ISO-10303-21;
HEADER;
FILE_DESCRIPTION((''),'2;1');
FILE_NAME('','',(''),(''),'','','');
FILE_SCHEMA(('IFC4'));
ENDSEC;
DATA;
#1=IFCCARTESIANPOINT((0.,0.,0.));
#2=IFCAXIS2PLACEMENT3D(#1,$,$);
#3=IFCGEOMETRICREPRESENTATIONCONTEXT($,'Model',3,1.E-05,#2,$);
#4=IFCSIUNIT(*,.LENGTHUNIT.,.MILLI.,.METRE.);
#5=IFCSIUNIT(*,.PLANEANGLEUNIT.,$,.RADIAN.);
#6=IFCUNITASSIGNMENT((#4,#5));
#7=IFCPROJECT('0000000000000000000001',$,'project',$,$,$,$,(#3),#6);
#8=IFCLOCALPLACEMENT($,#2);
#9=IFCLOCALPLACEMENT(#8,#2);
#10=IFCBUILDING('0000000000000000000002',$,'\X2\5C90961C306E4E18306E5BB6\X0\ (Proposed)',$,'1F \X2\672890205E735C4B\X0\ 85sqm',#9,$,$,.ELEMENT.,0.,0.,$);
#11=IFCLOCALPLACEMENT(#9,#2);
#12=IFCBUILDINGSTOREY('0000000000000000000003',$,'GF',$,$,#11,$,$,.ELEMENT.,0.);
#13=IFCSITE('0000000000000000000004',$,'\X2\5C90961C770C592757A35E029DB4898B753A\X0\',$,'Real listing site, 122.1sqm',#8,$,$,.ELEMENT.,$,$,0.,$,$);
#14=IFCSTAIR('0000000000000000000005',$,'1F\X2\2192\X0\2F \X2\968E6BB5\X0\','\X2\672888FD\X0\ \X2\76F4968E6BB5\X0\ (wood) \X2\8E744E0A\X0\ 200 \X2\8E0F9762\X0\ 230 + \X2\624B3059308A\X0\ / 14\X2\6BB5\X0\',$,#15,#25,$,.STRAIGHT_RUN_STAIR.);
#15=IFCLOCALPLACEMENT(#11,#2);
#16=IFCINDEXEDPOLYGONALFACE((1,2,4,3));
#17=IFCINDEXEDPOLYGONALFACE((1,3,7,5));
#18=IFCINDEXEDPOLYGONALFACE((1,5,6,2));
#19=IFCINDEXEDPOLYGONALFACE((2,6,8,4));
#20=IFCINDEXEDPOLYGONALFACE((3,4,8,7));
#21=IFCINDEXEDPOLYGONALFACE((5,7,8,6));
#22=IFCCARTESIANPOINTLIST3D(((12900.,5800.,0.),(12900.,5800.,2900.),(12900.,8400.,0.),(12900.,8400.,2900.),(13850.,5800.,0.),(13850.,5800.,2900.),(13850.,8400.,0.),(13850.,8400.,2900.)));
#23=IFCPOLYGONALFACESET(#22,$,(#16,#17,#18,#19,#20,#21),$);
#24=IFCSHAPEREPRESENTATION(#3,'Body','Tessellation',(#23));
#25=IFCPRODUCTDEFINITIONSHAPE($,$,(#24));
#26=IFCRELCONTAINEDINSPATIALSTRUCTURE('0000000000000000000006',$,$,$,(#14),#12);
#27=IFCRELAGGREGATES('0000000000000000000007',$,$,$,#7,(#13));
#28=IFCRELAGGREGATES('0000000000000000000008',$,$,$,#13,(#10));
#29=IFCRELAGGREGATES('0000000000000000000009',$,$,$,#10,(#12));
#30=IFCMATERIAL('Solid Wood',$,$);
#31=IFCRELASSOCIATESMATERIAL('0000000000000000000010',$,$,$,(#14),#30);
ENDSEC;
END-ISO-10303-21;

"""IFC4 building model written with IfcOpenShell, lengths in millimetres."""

from ifc_helpers import new_model, si_unit, frame, frame_2d, origin, place, context, project, spatial, rectangle, extrude, material, element, save


model = new_model("IFC4")

# Units and contexts
model_context = context("Model", 3, precision=1e-05, world=origin())
ifc_project = project(units=[si_unit("LENGTHUNIT", "METRE", prefix="MILLI"), si_unit("PLANEANGLEUNIT", "RADIAN")], contexts=[model_context])

# Site, building, storey
site_placement = place(None, origin())
site = spatial("IfcSite", under=ifc_project, at=site_placement, Name="岐阜県大垣市鶴見町", ObjectType="Real listing site, 122.1sqm", CompositionType="ELEMENT", RefElevation=0.0)
building_placement = place(site_placement, origin())
building = spatial("IfcBuilding", under=site, at=building_placement, Name="岐阜の丘の家 (Proposed)", ObjectType="1F 木造平屋 85sqm", CompositionType="ELEMENT", ElevationOfRefHeight=0.0, ElevationOfTerrain=0.0)
storey_placement = place(building_placement, origin())
storey = spatial("IfcBuildingStorey", under=building, at=storey_placement, Name="GF", CompositionType="ELEMENT", Elevation=0.0)

# Shared definitions
ifc_material_1 = material(Name="Solid Wood")

# Stair
stair_placement = place(storey_placement, frame((6450.0, 2900.0, 0.0)))
element("IfcStair", 1, at=stair_placement, inside=storey, material=ifc_material_1, Name="1F→2F 階段", Description="木製 直階段 (wood) 蹴上 200 踏面 230 + 手すり / 14段", PredefinedType="STRAIGHT_RUN_STAIR", context=model_context, shape_type="SweptSolid", body=[
    extrude(rectangle(XDim=950.0, YDim=2600.0, at=frame_2d((475.0, 1300.0))), frame((6450.0, 2900.0, 0.0)), (0.0, 0.0, 1.0), 2900.0),
])

save(model, "model.ifc")
